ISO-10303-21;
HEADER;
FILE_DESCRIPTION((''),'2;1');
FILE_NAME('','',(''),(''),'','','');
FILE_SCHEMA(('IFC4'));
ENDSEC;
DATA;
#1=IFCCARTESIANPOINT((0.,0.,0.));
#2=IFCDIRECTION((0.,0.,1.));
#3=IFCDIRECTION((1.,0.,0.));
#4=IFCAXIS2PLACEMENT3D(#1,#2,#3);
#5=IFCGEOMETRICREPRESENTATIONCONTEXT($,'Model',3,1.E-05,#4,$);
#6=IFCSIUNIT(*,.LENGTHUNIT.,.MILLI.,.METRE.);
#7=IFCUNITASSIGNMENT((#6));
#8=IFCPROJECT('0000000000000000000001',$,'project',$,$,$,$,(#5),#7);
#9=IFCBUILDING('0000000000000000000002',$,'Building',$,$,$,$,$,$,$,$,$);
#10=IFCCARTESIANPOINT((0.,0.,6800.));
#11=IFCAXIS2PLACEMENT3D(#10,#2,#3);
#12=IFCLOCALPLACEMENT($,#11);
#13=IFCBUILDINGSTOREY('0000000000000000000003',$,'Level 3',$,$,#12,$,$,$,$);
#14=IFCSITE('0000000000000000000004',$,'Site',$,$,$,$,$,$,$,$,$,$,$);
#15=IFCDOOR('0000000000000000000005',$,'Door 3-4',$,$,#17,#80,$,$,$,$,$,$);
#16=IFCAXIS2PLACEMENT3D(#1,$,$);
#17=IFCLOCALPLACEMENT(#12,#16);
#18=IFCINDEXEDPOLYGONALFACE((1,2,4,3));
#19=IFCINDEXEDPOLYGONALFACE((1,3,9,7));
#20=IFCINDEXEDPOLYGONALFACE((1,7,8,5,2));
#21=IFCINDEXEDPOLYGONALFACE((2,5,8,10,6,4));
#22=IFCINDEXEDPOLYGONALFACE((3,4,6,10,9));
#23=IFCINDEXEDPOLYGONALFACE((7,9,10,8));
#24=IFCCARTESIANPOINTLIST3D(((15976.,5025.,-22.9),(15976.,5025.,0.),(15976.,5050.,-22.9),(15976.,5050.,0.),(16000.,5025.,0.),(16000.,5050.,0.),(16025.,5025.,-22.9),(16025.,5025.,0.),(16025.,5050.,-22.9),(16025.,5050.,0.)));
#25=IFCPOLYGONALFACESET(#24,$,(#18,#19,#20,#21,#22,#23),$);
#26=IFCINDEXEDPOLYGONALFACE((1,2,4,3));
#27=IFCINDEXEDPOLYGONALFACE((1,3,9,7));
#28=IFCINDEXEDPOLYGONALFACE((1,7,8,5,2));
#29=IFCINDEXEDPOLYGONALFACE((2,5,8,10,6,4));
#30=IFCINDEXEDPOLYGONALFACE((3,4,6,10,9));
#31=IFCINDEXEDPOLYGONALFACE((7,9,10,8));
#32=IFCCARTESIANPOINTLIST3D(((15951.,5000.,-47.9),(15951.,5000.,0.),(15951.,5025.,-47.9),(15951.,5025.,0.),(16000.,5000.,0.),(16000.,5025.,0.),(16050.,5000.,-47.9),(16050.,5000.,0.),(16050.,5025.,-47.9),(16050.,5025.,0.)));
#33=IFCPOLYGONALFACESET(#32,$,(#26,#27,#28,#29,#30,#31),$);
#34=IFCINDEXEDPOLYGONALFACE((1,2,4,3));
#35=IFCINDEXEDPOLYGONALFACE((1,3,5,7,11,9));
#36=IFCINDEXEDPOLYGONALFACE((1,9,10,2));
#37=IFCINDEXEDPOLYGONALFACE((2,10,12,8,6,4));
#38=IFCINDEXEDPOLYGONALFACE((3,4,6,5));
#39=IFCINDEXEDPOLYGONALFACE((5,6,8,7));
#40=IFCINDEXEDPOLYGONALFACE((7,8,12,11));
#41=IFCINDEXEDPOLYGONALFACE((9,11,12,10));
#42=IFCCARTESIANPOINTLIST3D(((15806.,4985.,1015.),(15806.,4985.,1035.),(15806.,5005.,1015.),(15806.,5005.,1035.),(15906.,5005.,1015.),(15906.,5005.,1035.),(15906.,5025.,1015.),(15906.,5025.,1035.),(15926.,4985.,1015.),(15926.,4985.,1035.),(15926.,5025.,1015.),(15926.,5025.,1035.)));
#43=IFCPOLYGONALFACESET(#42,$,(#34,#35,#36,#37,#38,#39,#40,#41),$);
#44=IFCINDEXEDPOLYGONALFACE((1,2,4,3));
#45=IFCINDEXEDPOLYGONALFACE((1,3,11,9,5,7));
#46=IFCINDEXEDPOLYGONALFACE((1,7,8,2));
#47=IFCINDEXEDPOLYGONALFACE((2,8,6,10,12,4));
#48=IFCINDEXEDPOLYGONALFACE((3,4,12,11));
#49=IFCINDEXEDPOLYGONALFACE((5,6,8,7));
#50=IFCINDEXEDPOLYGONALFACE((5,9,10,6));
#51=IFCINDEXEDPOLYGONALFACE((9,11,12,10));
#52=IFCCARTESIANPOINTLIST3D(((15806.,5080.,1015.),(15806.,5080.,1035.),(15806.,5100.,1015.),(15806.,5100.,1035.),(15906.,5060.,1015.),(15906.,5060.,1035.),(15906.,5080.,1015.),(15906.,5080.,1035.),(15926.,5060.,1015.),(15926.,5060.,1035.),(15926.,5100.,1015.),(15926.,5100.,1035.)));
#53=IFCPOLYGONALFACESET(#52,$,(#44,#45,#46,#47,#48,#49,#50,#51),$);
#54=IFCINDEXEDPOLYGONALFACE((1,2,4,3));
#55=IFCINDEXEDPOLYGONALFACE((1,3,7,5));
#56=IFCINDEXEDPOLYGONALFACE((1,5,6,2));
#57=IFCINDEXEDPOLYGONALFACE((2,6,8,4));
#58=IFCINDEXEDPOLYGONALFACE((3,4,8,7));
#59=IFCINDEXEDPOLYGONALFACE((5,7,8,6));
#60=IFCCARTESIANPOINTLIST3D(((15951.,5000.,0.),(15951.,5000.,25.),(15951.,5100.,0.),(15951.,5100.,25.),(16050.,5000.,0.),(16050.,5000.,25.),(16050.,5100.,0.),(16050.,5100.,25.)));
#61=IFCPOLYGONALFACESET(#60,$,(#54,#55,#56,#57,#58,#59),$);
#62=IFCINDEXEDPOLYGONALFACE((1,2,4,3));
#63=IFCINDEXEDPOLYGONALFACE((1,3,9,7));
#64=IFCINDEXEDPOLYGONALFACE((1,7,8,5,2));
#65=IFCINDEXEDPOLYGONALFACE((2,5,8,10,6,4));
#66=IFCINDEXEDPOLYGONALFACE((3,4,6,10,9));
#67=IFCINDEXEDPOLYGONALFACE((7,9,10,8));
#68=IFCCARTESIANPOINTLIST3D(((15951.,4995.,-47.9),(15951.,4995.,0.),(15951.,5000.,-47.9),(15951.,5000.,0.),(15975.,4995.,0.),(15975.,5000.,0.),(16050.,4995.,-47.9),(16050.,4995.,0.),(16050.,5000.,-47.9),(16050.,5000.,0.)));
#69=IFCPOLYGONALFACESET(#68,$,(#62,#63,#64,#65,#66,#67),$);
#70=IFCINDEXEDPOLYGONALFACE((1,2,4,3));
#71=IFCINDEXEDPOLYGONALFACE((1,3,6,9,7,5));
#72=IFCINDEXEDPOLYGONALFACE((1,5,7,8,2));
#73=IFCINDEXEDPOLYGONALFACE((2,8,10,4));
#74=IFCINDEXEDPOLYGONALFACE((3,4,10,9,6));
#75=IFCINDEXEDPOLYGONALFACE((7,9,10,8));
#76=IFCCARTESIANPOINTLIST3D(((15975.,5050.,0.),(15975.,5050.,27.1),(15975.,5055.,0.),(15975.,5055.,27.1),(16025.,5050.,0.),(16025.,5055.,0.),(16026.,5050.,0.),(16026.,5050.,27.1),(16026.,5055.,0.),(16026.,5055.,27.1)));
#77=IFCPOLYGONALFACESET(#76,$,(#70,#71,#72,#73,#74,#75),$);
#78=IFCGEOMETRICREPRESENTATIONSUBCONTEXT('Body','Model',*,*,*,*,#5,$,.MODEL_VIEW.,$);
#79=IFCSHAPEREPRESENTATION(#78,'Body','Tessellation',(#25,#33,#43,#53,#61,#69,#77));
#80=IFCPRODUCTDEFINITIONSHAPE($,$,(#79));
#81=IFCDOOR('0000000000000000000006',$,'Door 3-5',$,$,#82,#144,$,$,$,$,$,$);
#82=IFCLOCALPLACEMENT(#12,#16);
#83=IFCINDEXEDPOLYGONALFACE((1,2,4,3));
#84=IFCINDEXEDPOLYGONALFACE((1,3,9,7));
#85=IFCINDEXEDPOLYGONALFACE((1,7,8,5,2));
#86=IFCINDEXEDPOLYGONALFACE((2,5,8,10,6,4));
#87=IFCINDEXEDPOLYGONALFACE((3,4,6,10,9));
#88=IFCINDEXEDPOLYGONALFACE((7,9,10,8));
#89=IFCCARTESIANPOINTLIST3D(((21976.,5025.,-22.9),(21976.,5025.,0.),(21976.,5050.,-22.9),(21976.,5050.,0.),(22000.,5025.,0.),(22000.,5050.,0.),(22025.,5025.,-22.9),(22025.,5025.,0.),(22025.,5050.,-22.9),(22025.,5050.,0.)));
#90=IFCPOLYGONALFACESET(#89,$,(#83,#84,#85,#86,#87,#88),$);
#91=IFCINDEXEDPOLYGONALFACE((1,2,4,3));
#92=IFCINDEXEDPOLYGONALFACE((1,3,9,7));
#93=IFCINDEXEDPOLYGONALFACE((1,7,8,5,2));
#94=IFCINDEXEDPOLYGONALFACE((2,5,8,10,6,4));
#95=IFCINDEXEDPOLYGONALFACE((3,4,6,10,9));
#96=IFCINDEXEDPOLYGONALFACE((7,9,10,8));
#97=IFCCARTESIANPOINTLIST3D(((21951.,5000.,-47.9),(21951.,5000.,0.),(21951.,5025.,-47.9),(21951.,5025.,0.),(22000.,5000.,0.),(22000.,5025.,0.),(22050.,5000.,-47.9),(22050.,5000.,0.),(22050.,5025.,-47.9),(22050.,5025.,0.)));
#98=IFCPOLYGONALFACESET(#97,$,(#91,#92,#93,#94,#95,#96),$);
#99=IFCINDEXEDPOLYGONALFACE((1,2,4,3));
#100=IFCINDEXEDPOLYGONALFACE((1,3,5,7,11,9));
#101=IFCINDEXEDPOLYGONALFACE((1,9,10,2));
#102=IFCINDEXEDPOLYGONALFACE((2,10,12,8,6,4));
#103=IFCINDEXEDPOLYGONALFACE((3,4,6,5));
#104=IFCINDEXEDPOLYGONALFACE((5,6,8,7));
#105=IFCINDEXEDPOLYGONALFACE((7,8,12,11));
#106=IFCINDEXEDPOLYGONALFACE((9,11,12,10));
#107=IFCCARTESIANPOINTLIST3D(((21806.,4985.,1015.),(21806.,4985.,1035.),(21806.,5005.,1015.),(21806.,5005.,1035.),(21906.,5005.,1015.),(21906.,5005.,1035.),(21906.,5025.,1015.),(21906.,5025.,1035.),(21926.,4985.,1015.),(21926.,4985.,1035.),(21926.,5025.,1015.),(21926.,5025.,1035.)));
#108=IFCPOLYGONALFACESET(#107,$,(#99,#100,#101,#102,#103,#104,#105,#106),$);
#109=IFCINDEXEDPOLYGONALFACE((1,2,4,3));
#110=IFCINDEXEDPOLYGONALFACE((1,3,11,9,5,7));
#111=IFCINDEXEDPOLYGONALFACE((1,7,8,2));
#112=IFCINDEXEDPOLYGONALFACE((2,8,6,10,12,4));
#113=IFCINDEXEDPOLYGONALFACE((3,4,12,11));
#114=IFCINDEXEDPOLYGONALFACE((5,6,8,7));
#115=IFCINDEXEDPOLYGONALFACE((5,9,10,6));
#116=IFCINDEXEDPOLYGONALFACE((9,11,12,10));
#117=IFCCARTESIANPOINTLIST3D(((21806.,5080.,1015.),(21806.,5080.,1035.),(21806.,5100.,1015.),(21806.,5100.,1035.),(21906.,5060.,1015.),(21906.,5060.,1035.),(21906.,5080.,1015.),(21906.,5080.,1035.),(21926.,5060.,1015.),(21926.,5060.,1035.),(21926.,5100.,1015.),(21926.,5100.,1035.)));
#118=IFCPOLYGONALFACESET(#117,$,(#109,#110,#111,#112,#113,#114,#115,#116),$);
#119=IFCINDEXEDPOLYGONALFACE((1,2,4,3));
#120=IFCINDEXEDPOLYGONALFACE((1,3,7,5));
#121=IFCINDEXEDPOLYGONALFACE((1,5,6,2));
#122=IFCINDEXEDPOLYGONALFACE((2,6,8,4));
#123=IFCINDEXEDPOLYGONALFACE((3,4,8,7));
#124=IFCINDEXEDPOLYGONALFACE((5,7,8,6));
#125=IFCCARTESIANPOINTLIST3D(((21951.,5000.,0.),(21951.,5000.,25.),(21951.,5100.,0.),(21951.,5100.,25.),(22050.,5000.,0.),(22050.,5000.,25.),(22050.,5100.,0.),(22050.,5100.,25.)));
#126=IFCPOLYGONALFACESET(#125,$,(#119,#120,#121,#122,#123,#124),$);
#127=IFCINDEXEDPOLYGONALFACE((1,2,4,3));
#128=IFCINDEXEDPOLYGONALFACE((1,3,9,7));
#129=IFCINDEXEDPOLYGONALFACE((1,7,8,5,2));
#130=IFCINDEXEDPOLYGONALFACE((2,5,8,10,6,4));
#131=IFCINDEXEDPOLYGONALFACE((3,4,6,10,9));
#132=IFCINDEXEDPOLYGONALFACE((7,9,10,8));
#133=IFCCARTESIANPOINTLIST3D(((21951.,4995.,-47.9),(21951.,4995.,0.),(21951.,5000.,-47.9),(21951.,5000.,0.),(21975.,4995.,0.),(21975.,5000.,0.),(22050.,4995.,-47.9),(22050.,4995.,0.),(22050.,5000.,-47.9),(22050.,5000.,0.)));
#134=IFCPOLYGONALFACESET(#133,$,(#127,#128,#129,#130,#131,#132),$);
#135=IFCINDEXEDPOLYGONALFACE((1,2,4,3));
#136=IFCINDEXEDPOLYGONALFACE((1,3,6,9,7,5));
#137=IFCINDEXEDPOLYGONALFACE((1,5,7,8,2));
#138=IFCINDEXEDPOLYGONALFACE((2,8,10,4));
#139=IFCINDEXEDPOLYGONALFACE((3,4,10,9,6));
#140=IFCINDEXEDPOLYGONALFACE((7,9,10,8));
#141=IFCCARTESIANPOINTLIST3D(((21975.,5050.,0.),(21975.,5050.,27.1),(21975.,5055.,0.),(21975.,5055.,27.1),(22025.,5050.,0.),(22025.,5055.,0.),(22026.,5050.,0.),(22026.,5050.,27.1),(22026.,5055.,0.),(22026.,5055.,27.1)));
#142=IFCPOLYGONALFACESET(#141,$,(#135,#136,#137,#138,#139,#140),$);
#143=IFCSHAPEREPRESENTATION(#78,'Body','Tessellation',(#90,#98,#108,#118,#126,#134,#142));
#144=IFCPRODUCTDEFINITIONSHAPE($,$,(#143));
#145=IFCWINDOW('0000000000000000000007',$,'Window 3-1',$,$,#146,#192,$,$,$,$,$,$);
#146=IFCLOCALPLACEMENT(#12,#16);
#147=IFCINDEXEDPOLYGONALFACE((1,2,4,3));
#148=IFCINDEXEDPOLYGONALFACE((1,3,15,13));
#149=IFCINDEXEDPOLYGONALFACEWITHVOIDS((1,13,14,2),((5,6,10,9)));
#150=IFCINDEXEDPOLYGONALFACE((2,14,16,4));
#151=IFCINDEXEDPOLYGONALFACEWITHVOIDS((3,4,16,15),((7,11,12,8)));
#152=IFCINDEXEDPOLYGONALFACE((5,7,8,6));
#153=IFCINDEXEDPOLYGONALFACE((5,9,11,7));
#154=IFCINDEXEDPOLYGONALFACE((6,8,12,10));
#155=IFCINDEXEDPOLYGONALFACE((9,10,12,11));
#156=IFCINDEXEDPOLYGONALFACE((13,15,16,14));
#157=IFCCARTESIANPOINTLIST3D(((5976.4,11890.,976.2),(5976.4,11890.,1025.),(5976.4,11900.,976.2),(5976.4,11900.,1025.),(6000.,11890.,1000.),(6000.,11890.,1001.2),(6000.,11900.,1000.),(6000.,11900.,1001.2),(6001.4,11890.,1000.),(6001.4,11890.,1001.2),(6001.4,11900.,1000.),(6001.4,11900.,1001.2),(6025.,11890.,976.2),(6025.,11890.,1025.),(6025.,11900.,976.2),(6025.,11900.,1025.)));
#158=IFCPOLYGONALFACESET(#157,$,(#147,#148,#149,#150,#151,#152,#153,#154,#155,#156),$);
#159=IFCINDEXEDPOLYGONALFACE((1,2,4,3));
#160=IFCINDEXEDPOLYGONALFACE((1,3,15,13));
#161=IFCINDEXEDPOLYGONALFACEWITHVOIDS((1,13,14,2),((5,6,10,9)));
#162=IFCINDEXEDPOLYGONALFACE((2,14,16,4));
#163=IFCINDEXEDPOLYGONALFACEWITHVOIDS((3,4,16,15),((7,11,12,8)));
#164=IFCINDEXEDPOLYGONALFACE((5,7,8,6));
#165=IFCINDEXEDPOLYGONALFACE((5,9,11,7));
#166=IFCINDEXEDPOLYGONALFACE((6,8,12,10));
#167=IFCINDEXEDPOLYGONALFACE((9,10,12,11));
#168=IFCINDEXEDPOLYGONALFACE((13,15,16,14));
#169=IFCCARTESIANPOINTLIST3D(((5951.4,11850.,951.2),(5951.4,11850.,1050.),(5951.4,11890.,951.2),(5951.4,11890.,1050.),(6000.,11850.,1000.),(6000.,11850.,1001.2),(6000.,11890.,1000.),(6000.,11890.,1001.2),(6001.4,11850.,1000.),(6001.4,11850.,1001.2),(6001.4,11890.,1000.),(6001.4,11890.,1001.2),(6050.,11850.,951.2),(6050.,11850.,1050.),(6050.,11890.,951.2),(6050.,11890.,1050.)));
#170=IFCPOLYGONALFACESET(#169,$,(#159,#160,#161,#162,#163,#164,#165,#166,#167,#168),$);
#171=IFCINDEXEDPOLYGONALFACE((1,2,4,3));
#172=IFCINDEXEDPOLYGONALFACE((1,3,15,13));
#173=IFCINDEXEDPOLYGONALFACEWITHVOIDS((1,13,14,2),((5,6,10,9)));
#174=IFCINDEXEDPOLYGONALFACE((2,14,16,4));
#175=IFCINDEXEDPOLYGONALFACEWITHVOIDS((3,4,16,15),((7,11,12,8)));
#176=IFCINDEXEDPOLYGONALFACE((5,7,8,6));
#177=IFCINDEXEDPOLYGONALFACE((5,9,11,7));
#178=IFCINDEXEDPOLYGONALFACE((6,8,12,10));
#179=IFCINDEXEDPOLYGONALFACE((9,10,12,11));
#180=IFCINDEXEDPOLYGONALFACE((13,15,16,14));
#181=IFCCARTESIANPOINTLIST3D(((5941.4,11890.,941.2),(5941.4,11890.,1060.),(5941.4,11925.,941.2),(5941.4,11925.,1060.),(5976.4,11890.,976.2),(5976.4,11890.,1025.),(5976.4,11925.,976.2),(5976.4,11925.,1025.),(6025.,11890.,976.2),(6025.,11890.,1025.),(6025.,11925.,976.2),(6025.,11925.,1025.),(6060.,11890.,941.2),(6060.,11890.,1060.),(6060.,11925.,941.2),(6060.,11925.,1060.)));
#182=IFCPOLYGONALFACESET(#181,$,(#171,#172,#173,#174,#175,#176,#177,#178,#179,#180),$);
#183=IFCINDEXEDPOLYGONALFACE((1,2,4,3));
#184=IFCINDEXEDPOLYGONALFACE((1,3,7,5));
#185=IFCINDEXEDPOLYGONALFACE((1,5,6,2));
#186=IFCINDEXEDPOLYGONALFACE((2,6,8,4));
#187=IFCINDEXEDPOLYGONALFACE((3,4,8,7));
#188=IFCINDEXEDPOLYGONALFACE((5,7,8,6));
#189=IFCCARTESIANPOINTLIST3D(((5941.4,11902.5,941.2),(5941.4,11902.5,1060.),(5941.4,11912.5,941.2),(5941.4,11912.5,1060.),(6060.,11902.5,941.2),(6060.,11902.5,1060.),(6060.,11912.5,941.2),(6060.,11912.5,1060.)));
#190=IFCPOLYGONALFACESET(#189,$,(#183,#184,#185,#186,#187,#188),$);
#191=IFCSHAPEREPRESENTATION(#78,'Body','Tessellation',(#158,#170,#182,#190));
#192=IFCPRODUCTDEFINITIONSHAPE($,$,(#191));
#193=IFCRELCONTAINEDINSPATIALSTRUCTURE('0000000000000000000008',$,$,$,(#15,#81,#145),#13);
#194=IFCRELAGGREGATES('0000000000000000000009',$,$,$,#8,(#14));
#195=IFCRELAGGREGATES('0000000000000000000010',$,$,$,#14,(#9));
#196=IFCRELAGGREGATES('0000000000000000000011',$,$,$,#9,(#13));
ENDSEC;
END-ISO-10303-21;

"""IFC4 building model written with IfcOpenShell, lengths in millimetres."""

from ifc_helpers import new_model, si_unit, frame, origin_with_axes, place, context, subcontext, project, spatial, line, indexed_curve, outline, extrude, element, save


model = new_model("IFC4")

# Units and contexts
model_context = context("Model", 3, precision=1e-05, world=origin_with_axes())
body_context = subcontext(model_context, "Body", "Model", "MODEL_VIEW")
ifc_project = project(units=[si_unit("LENGTHUNIT", "METRE", prefix="MILLI")], contexts=[model_context])

# Site, building, storey
site = spatial("IfcSite", under=ifc_project, Name="Site")
building = spatial("IfcBuilding", under=site, Name="Building")
storey_placement = place(None, frame((0.0, 0.0, 6800.0), z_axis=(0.0, 0.0, 1.0), x_axis=(1.0, 0.0, 0.0)))
storey = spatial("IfcBuildingStorey", under=building, at=storey_placement, Name="Level 3")

# Doors
door_1_placement = place(storey_placement, frame((16000.0, 5000.0, 0.0), z_axis=(0.0, 0.0, 1.0), x_axis=(1.0, 0.0, 0.0)))
element("IfcDoor", 1, at=door_1_placement, inside=storey, Name="Door 3-4", context=body_context, shape_type="SweptSolid", body=[
    extrude(outline(indexed_curve([(0.0, 0.0), (0.0, 2.1), (1.0, 2.1), (1.0, 0.0), (-24.0, 0.0), (-24.0, -22.9), (25.0, -22.9), (25.0, 0.0)], segments=[line(1, 2, 3, 4, 5, 6, 7, 8, 1)])), frame((0.0, 25.0, 0.0), z_axis=(0.0, -1.0, 0.0), x_axis=(1.0, 0.0, 0.0)), (0.0, 0.0, -1.0), 25.0),
    extrude(outline(indexed_curve([(0.0, 0.0), (0.0, 2.1), (1.0, 2.1), (1.0, 0.0), (-49.0, 0.0), (-49.0, -47.9), (50.0, -47.9), (50.0, 0.0)], segments=[line(1, 2, 3, 4, 5, 6, 7, 8, 1)])), frame((0.0, 0.0, 0.0), z_axis=(0.0, -1.0, 0.0), x_axis=(1.0, 0.0, 0.0)), (0.0, 0.0, -1.0), 25.0),
    extrude(outline(indexed_curve([(0.0, 0.0), (-49.0, 0.0), (-49.0, 35.0), (0.0, 35.0)], segments=[line(1, 2, 3, 4, 1)])), frame((25.0, 25.0, 25.0), z_axis=(0.0, 0.0, 1.0), x_axis=(1.0, 0.0, 0.0)), (0.0, 0.0, 1.0), -47.9),
    extrude(outline(indexed_curve([(0.0, 0.0), (0.0, -40.0), (-120.0, -40.0), (-120.0, -20.0), (-20.0, -20.0), (-20.0, 0.0)], segments=[line(1, 2, 3, 4, 5, 6, 1)])), frame((-74.0, 25.0, 1015.0), z_axis=(0.0, 0.0, 1.0), x_axis=(1.0, 0.0, 0.0)), (0.0, 0.0, 1.0), 20.0),
    extrude(outline(indexed_curve([(0.0, 0.0), (0.0, 40.0), (-120.0, 40.0), (-120.0, 20.0), (-20.0, 20.0), (-20.0, 0.0)], segments=[line(1, 2, 3, 4, 5, 6, 1)])), frame((-74.0, 60.0, 1015.0), z_axis=(0.0, 0.0, 1.0), x_axis=(1.0, 0.0, 0.0)), (0.0, 0.0, 1.0), 20.0),
    extrude(outline(indexed_curve([(0.0, 0.0), (-99.0, 0.0), (-99.0, 100.0), (0.0, 100.0)], segments=[line(1, 2, 3, 4, 1)])), frame((50.0, 0.0, 0.0), z_axis=(0.0, 0.0, 1.0), x_axis=(1.0, 0.0, 0.0)), (0.0, 0.0, 1.0), 25.0),
    extrude(outline(indexed_curve([(0.0, 0.0), (0.0, 27.1), (51.0, 27.1), (51.0, 0.0), (-24.0, 0.0), (-24.0, -47.9), (75.0, -47.9), (75.0, 0.0)], segments=[line(1, 2, 3, 4, 5, 6, 7, 8, 1)])), frame((-25.0, -5.0, 0.0), z_axis=(0.0, -1.0, 0.0), x_axis=(1.0, 0.0, 0.0)), (0.0, 0.0, -1.0), 5.0),
    extrude(outline(indexed_curve([(0.0, 0.0), (0.0, 27.1), (51.0, 27.1), (51.0, 0.0), (1.0, 0.0), (1.0, -22.9), (50.0, -22.9), (50.0, 0.0)], segments=[line(1, 2, 3, 4, 5, 6, 7, 8, 1)])), frame((-25.0, 50.0, 0.0), z_axis=(0.0, -1.0, 0.0), x_axis=(1.0, 0.0, 0.0)), (0.0, 0.0, -1.0), 5.0),
])
door_2_placement = place(storey_placement, frame((22000.0, 5000.0, 0.0), z_axis=(0.0, 0.0, 1.0), x_axis=(1.0, 0.0, 0.0)))
element("IfcDoor", 2, at=door_2_placement, inside=storey, Name="Door 3-5", context=body_context, shape_type="SweptSolid", body=[
    extrude(outline(indexed_curve([(0.0, 0.0), (0.0, 2.1), (1.0, 2.1), (1.0, 0.0), (-24.0, 0.0), (-24.0, -22.9), (25.0, -22.9), (25.0, 0.0)], segments=[line(1, 2, 3, 4, 5, 6, 7, 8, 1)])), frame((0.0, 25.0, 0.0), z_axis=(0.0, -1.0, 0.0), x_axis=(1.0, 0.0, 0.0)), (0.0, 0.0, -1.0), 25.0),
    extrude(outline(indexed_curve([(0.0, 0.0), (0.0, 2.1), (1.0, 2.1), (1.0, 0.0), (-49.0, 0.0), (-49.0, -47.9), (50.0, -47.9), (50.0, 0.0)], segments=[line(1, 2, 3, 4, 5, 6, 7, 8, 1)])), frame((0.0, 0.0, 0.0), z_axis=(0.0, -1.0, 0.0), x_axis=(1.0, 0.0, 0.0)), (0.0, 0.0, -1.0), 25.0),
    extrude(outline(indexed_curve([(0.0, 0.0), (-49.0, 0.0), (-49.0, 35.0), (0.0, 35.0)], segments=[line(1, 2, 3, 4, 1)])), frame((25.0, 25.0, 25.0), z_axis=(0.0, 0.0, 1.0), x_axis=(1.0, 0.0, 0.0)), (0.0, 0.0, 1.0), -47.9),
    extrude(outline(indexed_curve([(0.0, 0.0), (0.0, -40.0), (-120.0, -40.0), (-120.0, -20.0), (-20.0, -20.0), (-20.0, 0.0)], segments=[line(1, 2, 3, 4, 5, 6, 1)])), frame((-74.0, 25.0, 1015.0), z_axis=(0.0, 0.0, 1.0), x_axis=(1.0, 0.0, 0.0)), (0.0, 0.0, 1.0), 20.0),
    extrude(outline(indexed_curve([(0.0, 0.0), (0.0, 40.0), (-120.0, 40.0), (-120.0, 20.0), (-20.0, 20.0), (-20.0, 0.0)], segments=[line(1, 2, 3, 4, 5, 6, 1)])), frame((-74.0, 60.0, 1015.0), z_axis=(0.0, 0.0, 1.0), x_axis=(1.0, 0.0, 0.0)), (0.0, 0.0, 1.0), 20.0),
    extrude(outline(indexed_curve([(0.0, 0.0), (-99.0, 0.0), (-99.0, 100.0), (0.0, 100.0)], segments=[line(1, 2, 3, 4, 1)])), frame((50.0, 0.0, 0.0), z_axis=(0.0, 0.0, 1.0), x_axis=(1.0, 0.0, 0.0)), (0.0, 0.0, 1.0), 25.0),
    extrude(outline(indexed_curve([(0.0, 0.0), (0.0, 27.1), (51.0, 27.1), (51.0, 0.0), (-24.0, 0.0), (-24.0, -47.9), (75.0, -47.9), (75.0, 0.0)], segments=[line(1, 2, 3, 4, 5, 6, 7, 8, 1)])), frame((-25.0, -5.0, 0.0), z_axis=(0.0, -1.0, 0.0), x_axis=(1.0, 0.0, 0.0)), (0.0, 0.0, -1.0), 5.0),
    extrude(outline(indexed_curve([(0.0, 0.0), (0.0, 27.1), (51.0, 27.1), (51.0, 0.0), (1.0, 0.0), (1.0, -22.9), (50.0, -22.9), (50.0, 0.0)], segments=[line(1, 2, 3, 4, 5, 6, 7, 8, 1)])), frame((-25.0, 50.0, 0.0), z_axis=(0.0, -1.0, 0.0), x_axis=(1.0, 0.0, 0.0)), (0.0, 0.0, -1.0), 5.0),
])

# Window
for number, where, z_axis, x_axis, name in (
    (3, (6000.0, 11800.0, 1000.0), (0.0, 0.0, 1.0), (1.0, 0.0, 0.0), "Window 3-1"),
):
    element("IfcWindow", number, at=place(storey_placement, frame(where, z_axis=z_axis, x_axis=x_axis)), inside=storey, Name=name, context=body_context, shape_type="SweptSolid", body=[
        extrude(outline(indexed_curve([(0.0, 0.0), (1.4, 0.0), (1.4, 1.2), (0.0, 1.2)], segments=[line(1, 2, 3, 4, 1)]), holes=[indexed_curve([(25.0, 25.0), (-23.6, 25.0), (-23.6, -23.8), (25.0, -23.8)], segments=[line(1, 2, 3, 4, 1)])]), frame((0.0, 90.0, 0.0), z_axis=(0.0, -1.0, 0.0), x_axis=(1.0, 0.0, 0.0)), (0.0, 0.0, -1.0), 10.0),
        extrude(outline(indexed_curve([(0.0, 0.0), (1.4, 0.0), (1.4, 1.2), (0.0, 1.2)], segments=[line(1, 2, 3, 4, 1)]), holes=[indexed_curve([(50.0, 50.0), (-48.6, 50.0), (-48.6, -48.8), (50.0, -48.8)], segments=[line(1, 2, 3, 4, 1)])]), frame((0.0, 50.0, 0.0), z_axis=(0.0, -1.0, 0.0), x_axis=(1.0, 0.0, 0.0)), (0.0, 0.0, -1.0), 40.0),
        extrude(outline(indexed_curve([(0.0, 0.0), (-48.6, 0.0), (-48.6, -48.8), (0.0, -48.8)], segments=[line(1, 2, 3, 4, 1)]), holes=[indexed_curve([(35.0, 35.0), (-83.6, 35.0), (-83.6, -83.8), (35.0, -83.8)], segments=[line(1, 2, 3, 4, 1)])]), frame((25.0, 90.0, 25.0), z_axis=(0.0, -1.0, 0.0), x_axis=(1.0, 0.0, 0.0)), (0.0, 0.0, -1.0), 35.0),
        extrude(outline(indexed_curve([(35.0, 35.0), (-83.6, 35.0), (-83.6, -83.8), (35.0, -83.8)], segments=[line(1, 2, 3, 4, 1)])), frame((25.0, 102.5, 25.0), z_axis=(0.0, -1.0, 0.0), x_axis=(1.0, 0.0, 0.0)), (0.0, 0.0, -1.0), 10.0),
    ])

save(model, "model.ifc")
